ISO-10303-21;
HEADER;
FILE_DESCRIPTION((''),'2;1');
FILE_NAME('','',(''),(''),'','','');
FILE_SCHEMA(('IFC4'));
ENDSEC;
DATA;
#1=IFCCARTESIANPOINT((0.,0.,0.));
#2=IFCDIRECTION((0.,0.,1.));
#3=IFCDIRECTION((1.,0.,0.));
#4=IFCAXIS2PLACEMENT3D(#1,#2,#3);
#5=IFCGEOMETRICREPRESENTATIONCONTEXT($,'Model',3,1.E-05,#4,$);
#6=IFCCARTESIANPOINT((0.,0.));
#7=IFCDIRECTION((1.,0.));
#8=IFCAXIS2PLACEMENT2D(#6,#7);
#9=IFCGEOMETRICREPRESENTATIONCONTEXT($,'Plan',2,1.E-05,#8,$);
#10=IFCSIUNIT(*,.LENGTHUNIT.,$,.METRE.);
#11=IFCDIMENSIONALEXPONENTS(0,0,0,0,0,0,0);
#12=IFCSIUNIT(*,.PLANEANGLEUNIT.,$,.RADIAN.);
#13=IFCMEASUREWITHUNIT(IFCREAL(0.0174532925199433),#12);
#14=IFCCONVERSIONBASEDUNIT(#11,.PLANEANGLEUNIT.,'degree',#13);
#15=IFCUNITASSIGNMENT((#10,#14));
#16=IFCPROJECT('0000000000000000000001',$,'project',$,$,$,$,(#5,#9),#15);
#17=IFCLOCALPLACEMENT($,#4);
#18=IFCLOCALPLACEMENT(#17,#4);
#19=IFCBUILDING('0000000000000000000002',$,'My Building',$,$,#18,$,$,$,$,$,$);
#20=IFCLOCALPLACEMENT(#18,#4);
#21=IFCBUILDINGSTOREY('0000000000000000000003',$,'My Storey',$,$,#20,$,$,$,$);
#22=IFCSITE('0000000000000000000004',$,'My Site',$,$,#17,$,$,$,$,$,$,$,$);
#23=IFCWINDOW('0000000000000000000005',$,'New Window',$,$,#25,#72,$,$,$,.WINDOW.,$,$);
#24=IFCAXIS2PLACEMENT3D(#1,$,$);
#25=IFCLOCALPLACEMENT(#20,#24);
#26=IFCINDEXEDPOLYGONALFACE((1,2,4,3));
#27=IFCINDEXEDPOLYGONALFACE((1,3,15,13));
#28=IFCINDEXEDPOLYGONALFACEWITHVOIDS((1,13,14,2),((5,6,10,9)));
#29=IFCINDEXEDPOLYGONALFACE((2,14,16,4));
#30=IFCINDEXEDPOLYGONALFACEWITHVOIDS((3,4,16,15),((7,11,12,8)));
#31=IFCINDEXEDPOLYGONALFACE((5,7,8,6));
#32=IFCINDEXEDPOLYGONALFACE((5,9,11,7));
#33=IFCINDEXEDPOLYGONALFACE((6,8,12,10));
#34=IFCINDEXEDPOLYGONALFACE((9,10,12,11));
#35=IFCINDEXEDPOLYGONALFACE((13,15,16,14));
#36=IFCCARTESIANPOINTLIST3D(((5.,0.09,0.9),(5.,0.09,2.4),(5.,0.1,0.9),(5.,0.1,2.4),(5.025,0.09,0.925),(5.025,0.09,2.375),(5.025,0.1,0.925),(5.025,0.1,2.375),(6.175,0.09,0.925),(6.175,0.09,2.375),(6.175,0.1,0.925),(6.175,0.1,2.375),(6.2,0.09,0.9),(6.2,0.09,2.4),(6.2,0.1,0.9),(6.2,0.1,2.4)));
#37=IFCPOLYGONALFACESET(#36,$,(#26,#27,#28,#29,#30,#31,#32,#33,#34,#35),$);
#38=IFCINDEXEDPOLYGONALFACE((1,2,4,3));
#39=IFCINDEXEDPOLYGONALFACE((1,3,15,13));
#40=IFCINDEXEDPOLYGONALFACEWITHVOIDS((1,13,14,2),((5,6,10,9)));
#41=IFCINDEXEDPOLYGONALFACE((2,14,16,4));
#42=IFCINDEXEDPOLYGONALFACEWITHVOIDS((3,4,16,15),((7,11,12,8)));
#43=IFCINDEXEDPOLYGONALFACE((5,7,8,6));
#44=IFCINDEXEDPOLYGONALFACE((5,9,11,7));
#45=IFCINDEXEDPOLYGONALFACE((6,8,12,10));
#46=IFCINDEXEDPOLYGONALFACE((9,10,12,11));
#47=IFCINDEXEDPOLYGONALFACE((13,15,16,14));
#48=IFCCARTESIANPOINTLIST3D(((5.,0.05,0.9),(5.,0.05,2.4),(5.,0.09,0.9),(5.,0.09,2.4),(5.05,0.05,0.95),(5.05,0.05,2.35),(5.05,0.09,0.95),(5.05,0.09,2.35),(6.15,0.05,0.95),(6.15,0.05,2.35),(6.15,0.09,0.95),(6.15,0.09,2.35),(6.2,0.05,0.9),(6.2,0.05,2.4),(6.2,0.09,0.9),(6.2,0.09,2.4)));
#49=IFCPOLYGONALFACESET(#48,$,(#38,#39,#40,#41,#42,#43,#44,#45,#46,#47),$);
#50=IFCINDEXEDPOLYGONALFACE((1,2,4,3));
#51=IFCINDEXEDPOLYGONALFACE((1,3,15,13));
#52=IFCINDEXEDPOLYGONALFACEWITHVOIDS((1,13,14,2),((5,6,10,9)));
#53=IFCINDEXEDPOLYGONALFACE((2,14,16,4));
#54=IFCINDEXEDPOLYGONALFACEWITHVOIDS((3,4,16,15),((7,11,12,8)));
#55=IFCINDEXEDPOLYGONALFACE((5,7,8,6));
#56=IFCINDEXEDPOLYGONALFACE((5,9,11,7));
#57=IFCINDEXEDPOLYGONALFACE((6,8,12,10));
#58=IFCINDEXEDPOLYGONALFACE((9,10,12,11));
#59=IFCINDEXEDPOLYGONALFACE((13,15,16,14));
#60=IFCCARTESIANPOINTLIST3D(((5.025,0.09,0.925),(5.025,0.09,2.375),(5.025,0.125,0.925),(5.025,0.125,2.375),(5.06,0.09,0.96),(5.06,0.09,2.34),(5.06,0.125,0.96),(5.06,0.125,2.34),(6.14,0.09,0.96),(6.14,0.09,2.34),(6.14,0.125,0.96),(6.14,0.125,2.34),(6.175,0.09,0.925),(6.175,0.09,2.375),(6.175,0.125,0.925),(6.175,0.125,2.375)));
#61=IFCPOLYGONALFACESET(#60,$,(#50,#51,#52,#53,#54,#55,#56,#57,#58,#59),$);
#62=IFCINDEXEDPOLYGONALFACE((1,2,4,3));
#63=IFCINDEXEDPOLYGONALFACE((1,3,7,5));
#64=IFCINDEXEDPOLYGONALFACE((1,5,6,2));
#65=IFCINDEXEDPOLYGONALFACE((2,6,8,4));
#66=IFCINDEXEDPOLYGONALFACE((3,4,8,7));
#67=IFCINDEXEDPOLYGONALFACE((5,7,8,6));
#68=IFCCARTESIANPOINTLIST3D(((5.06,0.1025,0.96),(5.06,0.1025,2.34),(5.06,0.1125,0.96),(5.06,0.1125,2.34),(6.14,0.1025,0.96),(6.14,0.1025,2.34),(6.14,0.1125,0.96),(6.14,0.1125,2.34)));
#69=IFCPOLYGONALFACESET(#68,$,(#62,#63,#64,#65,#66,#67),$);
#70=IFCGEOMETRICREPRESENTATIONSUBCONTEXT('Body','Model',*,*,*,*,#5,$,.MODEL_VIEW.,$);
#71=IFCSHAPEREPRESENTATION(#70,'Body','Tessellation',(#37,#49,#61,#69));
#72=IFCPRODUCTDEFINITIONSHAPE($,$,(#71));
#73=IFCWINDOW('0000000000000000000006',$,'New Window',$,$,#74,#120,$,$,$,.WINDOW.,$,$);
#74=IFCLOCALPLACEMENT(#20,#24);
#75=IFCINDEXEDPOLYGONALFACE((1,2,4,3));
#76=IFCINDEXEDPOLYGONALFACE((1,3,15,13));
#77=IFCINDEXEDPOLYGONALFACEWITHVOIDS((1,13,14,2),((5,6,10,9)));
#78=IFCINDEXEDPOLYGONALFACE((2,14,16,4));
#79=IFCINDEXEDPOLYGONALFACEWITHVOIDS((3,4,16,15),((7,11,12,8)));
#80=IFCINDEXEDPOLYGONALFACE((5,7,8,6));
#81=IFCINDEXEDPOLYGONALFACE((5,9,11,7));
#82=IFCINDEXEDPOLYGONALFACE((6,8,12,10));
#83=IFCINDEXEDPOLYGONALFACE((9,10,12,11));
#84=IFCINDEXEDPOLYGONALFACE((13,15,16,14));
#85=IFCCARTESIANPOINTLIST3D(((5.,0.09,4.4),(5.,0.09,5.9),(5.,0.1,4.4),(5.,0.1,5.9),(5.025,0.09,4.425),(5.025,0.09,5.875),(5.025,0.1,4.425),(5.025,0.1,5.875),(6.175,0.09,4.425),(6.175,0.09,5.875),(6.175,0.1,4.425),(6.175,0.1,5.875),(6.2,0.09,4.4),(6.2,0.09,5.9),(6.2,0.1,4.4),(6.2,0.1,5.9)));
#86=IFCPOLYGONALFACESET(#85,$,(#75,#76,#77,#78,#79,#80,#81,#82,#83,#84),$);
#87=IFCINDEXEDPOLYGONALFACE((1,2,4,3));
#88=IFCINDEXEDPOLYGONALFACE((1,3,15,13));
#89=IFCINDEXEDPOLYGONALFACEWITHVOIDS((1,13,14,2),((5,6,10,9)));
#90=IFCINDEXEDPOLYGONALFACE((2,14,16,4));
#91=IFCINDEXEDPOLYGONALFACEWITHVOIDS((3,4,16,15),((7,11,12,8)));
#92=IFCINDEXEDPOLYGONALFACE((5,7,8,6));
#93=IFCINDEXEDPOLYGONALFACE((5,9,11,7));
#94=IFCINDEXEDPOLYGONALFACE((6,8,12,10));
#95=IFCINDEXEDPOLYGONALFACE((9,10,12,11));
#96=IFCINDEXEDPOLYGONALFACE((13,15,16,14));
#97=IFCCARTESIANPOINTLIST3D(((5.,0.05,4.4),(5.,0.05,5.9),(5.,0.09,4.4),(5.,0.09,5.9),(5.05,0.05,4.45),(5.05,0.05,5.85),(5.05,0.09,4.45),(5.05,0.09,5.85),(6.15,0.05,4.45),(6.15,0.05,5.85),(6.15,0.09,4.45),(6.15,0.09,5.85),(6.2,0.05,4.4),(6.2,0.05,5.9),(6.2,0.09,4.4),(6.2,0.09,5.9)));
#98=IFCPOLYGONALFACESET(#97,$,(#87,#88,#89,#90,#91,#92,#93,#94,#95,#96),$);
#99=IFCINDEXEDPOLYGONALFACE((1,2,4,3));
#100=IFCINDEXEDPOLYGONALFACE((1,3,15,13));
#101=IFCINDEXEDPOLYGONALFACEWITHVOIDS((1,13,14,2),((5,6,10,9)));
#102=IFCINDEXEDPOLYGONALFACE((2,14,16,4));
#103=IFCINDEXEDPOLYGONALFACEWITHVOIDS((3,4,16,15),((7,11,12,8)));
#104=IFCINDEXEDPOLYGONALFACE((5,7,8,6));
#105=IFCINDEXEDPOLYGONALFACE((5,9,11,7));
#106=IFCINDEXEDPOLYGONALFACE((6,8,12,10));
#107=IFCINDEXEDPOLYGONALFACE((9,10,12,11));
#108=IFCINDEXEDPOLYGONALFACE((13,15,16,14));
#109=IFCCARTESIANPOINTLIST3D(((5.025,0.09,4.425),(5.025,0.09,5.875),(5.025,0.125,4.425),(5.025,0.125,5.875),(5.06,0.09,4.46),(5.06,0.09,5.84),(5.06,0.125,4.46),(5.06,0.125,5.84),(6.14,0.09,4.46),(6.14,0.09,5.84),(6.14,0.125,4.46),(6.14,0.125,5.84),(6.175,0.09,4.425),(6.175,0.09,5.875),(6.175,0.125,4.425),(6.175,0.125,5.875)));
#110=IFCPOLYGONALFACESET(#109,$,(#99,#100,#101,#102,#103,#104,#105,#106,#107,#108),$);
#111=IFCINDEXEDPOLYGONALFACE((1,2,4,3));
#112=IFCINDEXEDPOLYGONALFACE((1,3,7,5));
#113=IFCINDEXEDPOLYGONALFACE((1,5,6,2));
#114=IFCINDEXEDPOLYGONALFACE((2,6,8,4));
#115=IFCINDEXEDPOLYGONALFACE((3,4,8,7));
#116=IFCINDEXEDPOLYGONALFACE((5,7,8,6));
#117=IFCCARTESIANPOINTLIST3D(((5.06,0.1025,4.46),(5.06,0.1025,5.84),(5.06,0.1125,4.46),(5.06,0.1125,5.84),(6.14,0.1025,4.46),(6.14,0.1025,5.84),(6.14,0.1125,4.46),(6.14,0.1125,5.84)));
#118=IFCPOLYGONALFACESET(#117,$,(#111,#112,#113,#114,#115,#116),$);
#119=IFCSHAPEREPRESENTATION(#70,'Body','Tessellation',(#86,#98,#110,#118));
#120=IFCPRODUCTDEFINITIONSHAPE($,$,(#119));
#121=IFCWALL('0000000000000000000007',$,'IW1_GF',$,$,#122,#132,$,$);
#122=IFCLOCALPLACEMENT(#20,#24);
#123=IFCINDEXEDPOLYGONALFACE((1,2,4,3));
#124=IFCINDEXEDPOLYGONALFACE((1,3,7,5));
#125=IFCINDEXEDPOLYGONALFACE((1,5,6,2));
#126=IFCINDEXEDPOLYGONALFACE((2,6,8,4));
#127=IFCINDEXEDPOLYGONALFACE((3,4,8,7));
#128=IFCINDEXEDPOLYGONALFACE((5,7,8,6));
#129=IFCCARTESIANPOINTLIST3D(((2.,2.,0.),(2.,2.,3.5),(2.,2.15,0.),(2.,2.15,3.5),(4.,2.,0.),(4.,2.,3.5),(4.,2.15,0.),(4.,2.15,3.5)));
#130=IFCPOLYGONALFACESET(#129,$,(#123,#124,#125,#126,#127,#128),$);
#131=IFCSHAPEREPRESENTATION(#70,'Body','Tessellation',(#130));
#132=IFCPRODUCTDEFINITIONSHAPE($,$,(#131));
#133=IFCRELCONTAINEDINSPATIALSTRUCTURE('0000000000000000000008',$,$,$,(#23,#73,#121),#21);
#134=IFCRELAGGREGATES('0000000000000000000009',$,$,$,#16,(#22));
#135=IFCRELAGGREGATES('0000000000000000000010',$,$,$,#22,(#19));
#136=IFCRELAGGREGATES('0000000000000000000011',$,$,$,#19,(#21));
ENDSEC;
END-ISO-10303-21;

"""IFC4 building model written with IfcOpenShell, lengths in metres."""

from ifc_helpers import new_model, entity, si_unit, converted_unit, frame, origin_with_axes, origin_2d_with_axis, place, context, subcontext, project, spatial, line, indexed_curve, outline, extrude, element, save


model = new_model("IFC4")

# Units and contexts
model_context = context("Model", 3, precision=1e-05, world=origin_with_axes())
plan_context = context("Plan", 2, precision=1e-05, world=origin_2d_with_axis())
body_context = subcontext(model_context, "Body", "Model", "MODEL_VIEW")
ifc_project = project(units=[si_unit("LENGTHUNIT", "METRE"), converted_unit("PLANEANGLEUNIT", "degree", entity("IfcReal", 0.0174532925199433), si_unit("PLANEANGLEUNIT", "RADIAN"), dimensions=[0, 0, 0, 0, 0, 0, 0])], contexts=[model_context, plan_context])

# Site, building, storey
site_placement = place(None, origin_with_axes())
site = spatial("IfcSite", under=ifc_project, at=site_placement, Name="My Site")
building_placement = place(site_placement, origin_with_axes())
building = spatial("IfcBuilding", under=site, at=building_placement, Name="My Building")
storey_placement = place(building_placement, origin_with_axes())
storey = spatial("IfcBuildingStorey", under=building, at=storey_placement, Name="My Storey")

# Windows
for number, where, z_axis, x_axis, name in (
    (1, (5.0, 0.0, 0.9), (0.0, 0.0, 1.0), (1.0, 0.0, 0.0), "New Window"),
    (2, (5.0, 0.0, 4.4), (0.0, 0.0, 1.0), (1.0, 0.0, 0.0), "New Window"),
):
    element("IfcWindow", number, at=place(storey_placement, frame(where, z_axis=z_axis, x_axis=x_axis)), inside=storey, Name=name, PredefinedType="WINDOW", context=body_context, shape_type="SweptSolid", body=[
        extrude(outline(indexed_curve([(0.0, 0.0), (1.2, 0.0), (1.2, 1.5), (0.0, 1.5)], segments=[line(1, 2, 3, 4, 1)]), holes=[indexed_curve([(0.025, 0.025), (1.175, 0.025), (1.175, 1.475), (0.025, 1.475)], segments=[line(1, 2, 3, 4, 1)])]), frame((0.0, 0.09, 0.0), z_axis=(0.0, -1.0, 0.0), x_axis=(1.0, 0.0, 0.0)), (0.0, 0.0, -1.0), 0.01),
        extrude(outline(indexed_curve([(0.0, 0.0), (1.2, 0.0), (1.2, 1.5), (0.0, 1.5)], segments=[line(1, 2, 3, 4, 1)]), holes=[indexed_curve([(0.05, 0.05), (1.15, 0.05), (1.15, 1.45), (0.05, 1.45)], segments=[line(1, 2, 3, 4, 1)])]), frame((0.0, 0.05, 0.0), z_axis=(0.0, -1.0, 0.0), x_axis=(1.0, 0.0, 0.0)), (0.0, 0.0, -1.0), 0.04),
        extrude(outline(indexed_curve([(0.0, 0.0), (1.15, 0.0), (1.15, 1.45), (0.0, 1.45)], segments=[line(1, 2, 3, 4, 1)]), holes=[indexed_curve([(0.035, 0.035), (1.115, 0.035), (1.115, 1.415), (0.035, 1.415)], segments=[line(1, 2, 3, 4, 1)])]), frame((0.025, 0.09, 0.025), z_axis=(0.0, -1.0, 0.0), x_axis=(1.0, 0.0, 0.0)), (0.0, 0.0, -1.0), 0.035),
        extrude(outline(indexed_curve([(0.035, 0.035), (1.115, 0.035), (1.115, 1.415), (0.035, 1.415)], segments=[line(1, 2, 3, 4, 1)])), frame((0.025, 0.1025, 0.025), z_axis=(0.0, -1.0, 0.0), x_axis=(1.0, 0.0, 0.0)), (0.0, 0.0, -1.0), 0.01),
    ])

# Wall
wall_1_placement = place(storey_placement, frame((2.0, 2.0, 0.0), z_axis=(0.0, 0.0, 1.0), x_axis=(1.0, 0.0, 0.0)))
element("IfcWall", 3, at=wall_1_placement, inside=storey, Name="IW1_GF", context=body_context, shape_type="SweptSolid", body=[
    extrude(outline(indexed_curve([(0.0, 0.0), (0.0, 0.15), (2.0, 0.15), (2.0, 0.0), (0.0, 0.0)], self_intersect=False)), origin_with_axes(), (0.0, 0.0, 1.0), 3.5),
])

save(model, "model.ifc")
